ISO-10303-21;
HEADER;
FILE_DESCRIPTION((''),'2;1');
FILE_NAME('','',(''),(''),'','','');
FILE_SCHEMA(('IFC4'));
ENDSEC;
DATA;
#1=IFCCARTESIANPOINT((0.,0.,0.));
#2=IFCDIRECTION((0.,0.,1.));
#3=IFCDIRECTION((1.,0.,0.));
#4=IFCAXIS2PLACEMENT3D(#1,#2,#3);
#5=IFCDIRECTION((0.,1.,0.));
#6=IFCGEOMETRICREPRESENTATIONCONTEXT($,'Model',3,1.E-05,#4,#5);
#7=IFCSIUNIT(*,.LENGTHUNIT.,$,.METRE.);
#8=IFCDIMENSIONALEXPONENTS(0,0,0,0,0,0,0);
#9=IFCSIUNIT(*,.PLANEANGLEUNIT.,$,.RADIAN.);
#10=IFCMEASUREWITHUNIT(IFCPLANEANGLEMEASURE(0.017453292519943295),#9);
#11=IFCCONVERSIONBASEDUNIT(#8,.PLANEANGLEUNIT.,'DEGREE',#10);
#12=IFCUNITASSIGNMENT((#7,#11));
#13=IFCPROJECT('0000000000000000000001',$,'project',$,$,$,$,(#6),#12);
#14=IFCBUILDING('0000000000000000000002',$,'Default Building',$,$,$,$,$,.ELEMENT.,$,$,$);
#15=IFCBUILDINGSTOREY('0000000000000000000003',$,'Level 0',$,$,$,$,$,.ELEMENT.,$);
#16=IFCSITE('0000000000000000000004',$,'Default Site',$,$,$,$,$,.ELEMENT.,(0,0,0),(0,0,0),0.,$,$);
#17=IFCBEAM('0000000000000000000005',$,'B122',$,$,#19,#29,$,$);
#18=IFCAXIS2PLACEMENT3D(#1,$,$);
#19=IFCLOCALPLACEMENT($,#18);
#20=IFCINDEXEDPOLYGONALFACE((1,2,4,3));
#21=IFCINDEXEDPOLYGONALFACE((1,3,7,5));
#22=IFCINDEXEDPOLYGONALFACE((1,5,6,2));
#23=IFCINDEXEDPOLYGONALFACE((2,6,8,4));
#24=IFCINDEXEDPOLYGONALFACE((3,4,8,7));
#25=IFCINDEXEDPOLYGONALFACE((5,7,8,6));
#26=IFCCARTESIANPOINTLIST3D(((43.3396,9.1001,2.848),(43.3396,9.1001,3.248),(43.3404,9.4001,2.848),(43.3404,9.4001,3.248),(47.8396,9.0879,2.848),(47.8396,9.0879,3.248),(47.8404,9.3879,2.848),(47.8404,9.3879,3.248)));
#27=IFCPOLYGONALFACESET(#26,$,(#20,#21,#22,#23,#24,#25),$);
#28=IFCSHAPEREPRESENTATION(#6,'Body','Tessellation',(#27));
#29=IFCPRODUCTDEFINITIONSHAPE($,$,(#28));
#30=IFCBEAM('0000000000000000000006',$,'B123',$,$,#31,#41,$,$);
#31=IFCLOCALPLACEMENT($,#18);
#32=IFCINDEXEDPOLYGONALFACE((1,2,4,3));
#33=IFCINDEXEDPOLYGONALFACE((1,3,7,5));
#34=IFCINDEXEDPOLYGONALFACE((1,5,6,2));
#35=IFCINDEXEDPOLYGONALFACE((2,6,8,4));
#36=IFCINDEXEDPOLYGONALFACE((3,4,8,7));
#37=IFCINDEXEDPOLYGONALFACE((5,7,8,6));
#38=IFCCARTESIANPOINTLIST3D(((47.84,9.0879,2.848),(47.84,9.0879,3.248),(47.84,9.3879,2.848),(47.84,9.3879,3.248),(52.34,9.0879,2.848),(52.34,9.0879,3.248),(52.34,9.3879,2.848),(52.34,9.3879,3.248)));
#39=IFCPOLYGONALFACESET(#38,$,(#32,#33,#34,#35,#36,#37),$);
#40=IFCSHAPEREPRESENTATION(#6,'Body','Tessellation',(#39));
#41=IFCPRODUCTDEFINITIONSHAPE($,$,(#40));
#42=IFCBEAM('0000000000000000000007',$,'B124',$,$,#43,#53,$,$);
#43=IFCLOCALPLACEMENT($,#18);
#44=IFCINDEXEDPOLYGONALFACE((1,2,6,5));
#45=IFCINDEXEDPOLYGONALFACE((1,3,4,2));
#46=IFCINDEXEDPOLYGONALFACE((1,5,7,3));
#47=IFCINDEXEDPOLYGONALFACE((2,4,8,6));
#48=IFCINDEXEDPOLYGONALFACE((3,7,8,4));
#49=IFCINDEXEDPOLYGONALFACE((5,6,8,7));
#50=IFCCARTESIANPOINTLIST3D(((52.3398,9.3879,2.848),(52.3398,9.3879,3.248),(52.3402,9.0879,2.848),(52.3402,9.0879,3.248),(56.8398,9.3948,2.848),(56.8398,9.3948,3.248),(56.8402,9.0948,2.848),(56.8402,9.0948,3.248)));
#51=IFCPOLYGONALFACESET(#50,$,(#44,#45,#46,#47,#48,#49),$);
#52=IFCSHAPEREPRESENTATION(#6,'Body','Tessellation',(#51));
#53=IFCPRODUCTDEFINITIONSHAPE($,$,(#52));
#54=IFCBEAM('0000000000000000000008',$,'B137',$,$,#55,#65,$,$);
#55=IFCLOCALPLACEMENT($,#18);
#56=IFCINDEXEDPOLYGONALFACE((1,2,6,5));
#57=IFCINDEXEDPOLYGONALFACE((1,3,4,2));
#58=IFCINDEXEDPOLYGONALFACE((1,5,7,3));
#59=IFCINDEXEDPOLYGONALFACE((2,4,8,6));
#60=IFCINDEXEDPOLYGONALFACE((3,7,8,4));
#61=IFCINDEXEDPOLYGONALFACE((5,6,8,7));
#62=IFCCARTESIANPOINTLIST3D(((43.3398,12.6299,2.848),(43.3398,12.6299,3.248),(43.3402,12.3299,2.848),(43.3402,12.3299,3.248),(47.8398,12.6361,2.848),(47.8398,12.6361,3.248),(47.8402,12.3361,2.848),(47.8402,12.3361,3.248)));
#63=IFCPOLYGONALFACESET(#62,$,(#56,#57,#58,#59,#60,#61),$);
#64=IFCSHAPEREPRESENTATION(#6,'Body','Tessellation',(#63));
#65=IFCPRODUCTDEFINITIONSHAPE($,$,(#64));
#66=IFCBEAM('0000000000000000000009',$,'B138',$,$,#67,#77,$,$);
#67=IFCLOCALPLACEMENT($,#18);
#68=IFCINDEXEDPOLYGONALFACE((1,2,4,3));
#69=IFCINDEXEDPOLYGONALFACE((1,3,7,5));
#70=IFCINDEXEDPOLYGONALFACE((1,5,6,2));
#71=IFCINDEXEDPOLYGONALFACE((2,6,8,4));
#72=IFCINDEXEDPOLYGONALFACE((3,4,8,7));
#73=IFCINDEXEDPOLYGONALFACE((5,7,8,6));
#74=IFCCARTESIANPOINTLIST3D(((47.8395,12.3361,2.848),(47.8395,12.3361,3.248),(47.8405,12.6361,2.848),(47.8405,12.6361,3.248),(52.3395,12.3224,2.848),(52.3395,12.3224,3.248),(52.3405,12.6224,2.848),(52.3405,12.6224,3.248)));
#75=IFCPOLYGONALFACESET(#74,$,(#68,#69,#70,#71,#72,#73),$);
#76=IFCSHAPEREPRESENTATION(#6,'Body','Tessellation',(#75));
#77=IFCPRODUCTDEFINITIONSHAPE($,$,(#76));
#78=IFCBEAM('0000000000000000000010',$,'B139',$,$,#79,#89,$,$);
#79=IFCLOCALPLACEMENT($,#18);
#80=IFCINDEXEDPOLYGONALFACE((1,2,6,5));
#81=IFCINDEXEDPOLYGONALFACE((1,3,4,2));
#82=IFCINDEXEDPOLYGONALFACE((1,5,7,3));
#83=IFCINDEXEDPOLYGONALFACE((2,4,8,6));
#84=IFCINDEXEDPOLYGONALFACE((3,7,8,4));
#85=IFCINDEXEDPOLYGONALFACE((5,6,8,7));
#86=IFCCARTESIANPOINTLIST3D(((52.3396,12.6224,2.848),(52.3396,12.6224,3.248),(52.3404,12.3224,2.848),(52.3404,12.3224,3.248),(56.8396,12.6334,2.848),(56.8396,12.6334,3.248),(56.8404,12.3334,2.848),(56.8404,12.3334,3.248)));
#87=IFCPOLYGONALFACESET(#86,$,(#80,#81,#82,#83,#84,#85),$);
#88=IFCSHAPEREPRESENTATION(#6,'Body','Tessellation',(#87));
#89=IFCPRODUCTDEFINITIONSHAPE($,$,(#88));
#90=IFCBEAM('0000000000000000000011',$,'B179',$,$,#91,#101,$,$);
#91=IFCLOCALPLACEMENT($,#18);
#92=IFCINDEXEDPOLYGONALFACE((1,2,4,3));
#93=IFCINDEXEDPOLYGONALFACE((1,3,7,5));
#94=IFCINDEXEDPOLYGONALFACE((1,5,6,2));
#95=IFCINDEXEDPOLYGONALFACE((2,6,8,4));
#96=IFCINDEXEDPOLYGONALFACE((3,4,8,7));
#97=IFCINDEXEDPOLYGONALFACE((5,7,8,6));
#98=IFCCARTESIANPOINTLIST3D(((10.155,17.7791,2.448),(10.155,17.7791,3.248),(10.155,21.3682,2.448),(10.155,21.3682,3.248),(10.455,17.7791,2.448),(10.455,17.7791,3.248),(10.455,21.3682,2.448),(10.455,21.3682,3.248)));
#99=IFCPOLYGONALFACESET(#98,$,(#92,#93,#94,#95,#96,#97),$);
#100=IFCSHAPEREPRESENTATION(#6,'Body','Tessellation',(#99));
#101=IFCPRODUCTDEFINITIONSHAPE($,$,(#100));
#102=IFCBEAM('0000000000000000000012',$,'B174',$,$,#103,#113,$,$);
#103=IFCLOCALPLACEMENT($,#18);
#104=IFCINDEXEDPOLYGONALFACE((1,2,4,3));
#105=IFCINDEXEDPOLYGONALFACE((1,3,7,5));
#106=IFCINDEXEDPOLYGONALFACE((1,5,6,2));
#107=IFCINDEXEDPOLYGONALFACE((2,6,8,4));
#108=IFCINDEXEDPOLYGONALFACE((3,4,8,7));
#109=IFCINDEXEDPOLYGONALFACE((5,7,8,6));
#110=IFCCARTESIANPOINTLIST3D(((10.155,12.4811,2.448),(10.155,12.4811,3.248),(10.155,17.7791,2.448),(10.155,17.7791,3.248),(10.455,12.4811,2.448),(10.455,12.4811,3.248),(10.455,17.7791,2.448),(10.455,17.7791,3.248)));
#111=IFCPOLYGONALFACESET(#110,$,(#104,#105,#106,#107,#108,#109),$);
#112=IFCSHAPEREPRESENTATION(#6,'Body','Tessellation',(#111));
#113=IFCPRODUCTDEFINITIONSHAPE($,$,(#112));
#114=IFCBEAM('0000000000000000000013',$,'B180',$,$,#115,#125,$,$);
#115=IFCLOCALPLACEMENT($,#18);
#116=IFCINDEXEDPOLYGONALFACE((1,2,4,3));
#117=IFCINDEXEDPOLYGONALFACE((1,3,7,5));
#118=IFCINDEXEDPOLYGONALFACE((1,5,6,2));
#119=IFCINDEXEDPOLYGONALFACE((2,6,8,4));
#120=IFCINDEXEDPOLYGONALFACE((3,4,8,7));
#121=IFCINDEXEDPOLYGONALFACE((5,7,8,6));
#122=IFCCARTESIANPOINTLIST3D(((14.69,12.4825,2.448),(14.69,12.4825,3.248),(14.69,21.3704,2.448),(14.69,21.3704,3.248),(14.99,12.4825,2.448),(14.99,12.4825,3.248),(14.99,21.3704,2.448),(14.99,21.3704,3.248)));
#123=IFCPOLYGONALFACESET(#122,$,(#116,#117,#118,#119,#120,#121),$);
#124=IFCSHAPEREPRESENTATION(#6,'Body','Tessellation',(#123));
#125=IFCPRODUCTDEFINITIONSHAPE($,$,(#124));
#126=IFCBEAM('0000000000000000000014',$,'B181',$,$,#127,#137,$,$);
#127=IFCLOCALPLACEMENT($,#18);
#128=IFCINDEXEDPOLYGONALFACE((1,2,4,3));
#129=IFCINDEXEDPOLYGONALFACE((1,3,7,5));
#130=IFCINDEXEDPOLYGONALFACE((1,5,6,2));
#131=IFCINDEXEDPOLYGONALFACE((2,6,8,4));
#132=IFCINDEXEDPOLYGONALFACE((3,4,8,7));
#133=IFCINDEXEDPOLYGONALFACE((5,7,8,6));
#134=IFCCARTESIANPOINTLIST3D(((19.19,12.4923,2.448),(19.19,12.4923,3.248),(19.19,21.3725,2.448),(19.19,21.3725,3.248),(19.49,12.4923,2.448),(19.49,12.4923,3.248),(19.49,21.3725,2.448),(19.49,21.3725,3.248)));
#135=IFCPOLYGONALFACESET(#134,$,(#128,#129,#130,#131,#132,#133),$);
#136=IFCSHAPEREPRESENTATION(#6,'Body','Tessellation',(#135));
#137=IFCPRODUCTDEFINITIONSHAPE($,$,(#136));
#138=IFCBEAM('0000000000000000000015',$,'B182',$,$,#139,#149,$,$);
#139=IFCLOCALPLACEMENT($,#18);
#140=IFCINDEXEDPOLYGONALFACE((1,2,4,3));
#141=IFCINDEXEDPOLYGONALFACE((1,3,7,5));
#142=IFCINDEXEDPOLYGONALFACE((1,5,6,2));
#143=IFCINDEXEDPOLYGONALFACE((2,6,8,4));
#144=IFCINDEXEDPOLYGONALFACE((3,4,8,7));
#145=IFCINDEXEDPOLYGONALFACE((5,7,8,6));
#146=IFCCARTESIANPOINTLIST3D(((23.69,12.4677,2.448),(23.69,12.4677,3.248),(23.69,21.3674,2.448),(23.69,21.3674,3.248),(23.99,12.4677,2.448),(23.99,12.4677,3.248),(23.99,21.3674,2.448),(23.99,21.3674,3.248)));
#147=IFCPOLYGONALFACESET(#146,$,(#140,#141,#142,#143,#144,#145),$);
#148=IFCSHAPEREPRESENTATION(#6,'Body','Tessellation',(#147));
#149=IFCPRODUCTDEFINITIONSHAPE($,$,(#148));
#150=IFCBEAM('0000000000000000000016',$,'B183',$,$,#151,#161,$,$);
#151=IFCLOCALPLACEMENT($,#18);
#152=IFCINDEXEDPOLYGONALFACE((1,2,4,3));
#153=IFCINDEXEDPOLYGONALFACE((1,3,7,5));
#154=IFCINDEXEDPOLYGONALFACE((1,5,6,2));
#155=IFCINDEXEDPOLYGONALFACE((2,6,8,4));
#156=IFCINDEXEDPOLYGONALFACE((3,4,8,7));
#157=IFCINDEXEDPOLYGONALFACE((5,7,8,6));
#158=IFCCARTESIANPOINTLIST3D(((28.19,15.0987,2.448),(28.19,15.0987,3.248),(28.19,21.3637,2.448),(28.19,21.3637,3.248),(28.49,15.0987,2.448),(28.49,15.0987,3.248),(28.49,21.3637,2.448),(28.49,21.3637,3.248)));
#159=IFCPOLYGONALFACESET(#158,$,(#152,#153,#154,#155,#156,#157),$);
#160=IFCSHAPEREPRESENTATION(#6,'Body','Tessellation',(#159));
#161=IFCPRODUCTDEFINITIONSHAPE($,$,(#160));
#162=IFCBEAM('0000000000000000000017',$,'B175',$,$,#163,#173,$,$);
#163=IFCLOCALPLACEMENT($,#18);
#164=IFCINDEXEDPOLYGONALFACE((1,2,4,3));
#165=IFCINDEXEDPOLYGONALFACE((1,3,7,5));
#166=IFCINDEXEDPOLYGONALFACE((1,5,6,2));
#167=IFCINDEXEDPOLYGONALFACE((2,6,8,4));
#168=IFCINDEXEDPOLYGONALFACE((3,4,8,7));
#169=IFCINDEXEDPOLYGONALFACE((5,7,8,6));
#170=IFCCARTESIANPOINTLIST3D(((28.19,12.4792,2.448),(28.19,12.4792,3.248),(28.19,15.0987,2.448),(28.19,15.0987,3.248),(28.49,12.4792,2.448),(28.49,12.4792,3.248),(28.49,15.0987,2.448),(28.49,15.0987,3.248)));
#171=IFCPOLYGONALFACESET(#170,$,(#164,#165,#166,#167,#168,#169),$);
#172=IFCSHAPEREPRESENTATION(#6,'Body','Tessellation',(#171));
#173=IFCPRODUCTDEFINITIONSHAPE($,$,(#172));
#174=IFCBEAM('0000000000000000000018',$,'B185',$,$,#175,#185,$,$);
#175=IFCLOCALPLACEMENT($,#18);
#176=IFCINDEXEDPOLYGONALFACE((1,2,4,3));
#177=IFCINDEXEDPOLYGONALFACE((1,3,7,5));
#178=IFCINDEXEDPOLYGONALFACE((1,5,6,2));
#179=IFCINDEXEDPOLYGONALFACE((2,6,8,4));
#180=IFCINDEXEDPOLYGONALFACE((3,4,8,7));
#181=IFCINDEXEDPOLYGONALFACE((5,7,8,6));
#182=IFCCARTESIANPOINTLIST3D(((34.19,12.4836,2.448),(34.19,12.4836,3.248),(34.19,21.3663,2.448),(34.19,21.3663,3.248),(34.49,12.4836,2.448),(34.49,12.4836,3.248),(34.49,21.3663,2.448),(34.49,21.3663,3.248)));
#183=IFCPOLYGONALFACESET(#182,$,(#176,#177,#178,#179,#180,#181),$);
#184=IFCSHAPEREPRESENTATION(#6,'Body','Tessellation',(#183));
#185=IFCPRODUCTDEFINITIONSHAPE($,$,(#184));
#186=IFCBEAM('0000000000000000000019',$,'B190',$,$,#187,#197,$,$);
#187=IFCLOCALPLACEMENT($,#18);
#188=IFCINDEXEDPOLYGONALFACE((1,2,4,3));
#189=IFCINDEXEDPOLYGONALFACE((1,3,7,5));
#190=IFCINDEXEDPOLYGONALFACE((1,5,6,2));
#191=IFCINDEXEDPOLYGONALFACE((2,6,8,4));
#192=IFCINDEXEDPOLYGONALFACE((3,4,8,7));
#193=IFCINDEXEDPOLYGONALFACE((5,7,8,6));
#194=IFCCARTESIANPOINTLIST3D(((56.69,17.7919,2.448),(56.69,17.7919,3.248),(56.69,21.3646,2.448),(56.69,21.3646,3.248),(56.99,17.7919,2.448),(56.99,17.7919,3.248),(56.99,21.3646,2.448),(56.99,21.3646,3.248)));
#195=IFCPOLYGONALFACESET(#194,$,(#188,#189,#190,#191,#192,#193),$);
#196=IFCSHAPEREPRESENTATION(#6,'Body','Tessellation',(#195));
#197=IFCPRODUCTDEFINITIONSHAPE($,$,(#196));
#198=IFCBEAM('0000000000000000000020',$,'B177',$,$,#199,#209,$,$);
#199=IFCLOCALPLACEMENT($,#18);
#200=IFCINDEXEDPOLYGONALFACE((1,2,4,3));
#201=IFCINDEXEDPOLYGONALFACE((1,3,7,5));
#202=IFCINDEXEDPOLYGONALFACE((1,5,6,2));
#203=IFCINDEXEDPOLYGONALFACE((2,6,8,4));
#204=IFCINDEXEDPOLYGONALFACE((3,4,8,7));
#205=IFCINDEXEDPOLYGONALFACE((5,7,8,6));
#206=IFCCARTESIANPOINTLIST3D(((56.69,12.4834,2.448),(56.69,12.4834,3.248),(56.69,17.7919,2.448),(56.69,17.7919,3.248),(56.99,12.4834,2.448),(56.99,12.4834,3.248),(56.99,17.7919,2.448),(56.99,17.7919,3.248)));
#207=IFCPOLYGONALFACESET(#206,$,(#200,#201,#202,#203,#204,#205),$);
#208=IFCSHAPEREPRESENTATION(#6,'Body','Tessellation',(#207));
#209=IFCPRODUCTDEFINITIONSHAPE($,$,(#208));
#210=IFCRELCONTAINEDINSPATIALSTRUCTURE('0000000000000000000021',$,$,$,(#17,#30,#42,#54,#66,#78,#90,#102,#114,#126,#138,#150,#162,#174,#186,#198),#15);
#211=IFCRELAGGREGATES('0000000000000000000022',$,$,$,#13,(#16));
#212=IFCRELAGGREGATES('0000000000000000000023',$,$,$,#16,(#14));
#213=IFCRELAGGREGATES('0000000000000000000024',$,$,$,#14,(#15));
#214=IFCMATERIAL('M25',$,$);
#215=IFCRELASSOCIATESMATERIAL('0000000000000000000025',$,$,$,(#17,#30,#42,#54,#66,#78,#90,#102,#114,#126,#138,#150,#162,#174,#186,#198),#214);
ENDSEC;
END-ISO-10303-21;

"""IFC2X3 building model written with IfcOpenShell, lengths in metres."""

from ifc_helpers import new_model, entity, si_unit, converted_unit, direction, frame, frame_2d, origin_with_axes, place, context, project, spatial, rectangle, extrude, material, element, save


model = new_model("IFC2X3")

# Units and contexts
model_context = context("Model", 3, precision=1e-05, world=origin_with_axes(), true_north=direction((0.0, 1.0, 0.0)))
ifc_project = project(units=[si_unit("LENGTHUNIT", "METRE"), converted_unit("PLANEANGLEUNIT", "DEGREE", entity("IfcPlaneAngleMeasure", 0.017453292519943295), si_unit("PLANEANGLEUNIT", "RADIAN"), dimensions=[0, 0, 0, 0, 0, 0, 0])], contexts=[model_context])

# Site, building, storey
site = spatial("IfcSite", under=ifc_project, Name="Default Site", CompositionType="ELEMENT", RefLatitude=(0, 0, 0), RefLongitude=(0, 0, 0), RefElevation=0.0)
building = spatial("IfcBuilding", under=site, Name="Default Building", CompositionType="ELEMENT")
storey = spatial("IfcBuildingStorey", under=building, Name="Level 0", CompositionType="ELEMENT")

# Beams
ifc_material = material(Name="M25")
placement = place(None, origin_with_axes())
element("IfcBeam", 1, at=placement, inside=storey, material=ifc_material, Name="B122", context=model_context, shape_type="SweptSolid", body=[
    extrude(rectangle(XDim=0.3, YDim=0.4, at=frame_2d((0.0, 0.0), x_axis=(0.0, 1.0, 0.0))), frame((43.34, 9.2501, 3.048), z_axis=(0.999996, -0.002702, 0.0), x_axis=(0.0, 0.0, -1.0)), (0.0, 0.0, 1.0), 4.5),
])
element("IfcBeam", 2, at=placement, inside=storey, material=ifc_material, Name="B123", context=model_context, shape_type="SweptSolid", body=[
    extrude(rectangle(XDim=0.3, YDim=0.4, at=frame_2d((0.0, 0.0), x_axis=(0.0, 1.0, 0.0))), frame((47.84, 9.2379, 3.048), z_axis=(1.0, 0.0, 0.0), x_axis=(0.0, 0.0, -1.0)), (0.0, 0.0, 1.0), 4.5),
])
element("IfcBeam", 3, at=placement, inside=storey, material=ifc_material, Name="B124", context=model_context, shape_type="SweptSolid", body=[
    extrude(rectangle(XDim=0.3, YDim=0.4, at=frame_2d((0.0, 0.0), x_axis=(0.0, 1.0, 0.0))), frame((52.34, 9.2379, 3.048), z_axis=(0.999999, 0.001537, 0.0), x_axis=(0.0, 0.0, -1.0)), (0.0, 0.0, 1.0), 4.5),
])
element("IfcBeam", 4, at=placement, inside=storey, material=ifc_material, Name="B137", context=model_context, shape_type="SweptSolid", body=[
    extrude(rectangle(XDim=0.3, YDim=0.4, at=frame_2d((0.0, 0.0), x_axis=(0.0, 1.0, 0.0))), frame((43.34, 12.4799, 3.048), z_axis=(0.999999, 0.001374, 0.0), x_axis=(0.0, 0.0, -1.0)), (0.0, 0.0, 1.0), 4.5),
])
element("IfcBeam", 5, at=placement, inside=storey, material=ifc_material, Name="B138", context=model_context, shape_type="SweptSolid", body=[
    extrude(rectangle(XDim=0.3, YDim=0.4, at=frame_2d((0.0, 0.0), x_axis=(0.0, 1.0, 0.0))), frame((47.84, 12.4861, 3.048), z_axis=(0.999995, -0.003045, 0.0), x_axis=(0.0, 0.0, -1.0)), (0.0, 0.0, 1.0), 4.5),
])
element("IfcBeam", 6, at=placement, inside=storey, material=ifc_material, Name="B139", context=model_context, shape_type="SweptSolid", body=[
    extrude(rectangle(XDim=0.3, YDim=0.4, at=frame_2d((0.0, 0.0), x_axis=(0.0, 1.0, 0.0))), frame((52.34, 12.4724, 3.048), z_axis=(0.999997, 0.002456, 0.0), x_axis=(0.0, 0.0, -1.0)), (0.0, 0.0, 1.0), 4.5),
])
element("IfcBeam", 7, at=placement, inside=storey, material=ifc_material, Name="B179", context=model_context, shape_type="SweptSolid", body=[
    extrude(rectangle(XDim=0.3, YDim=0.8, at=frame_2d((0.0, 0.0), x_axis=(0.0, 1.0, 0.0))), frame((10.305, 21.3682, 2.848), z_axis=(0.0, -1.0, 0.0), x_axis=(0.0, 0.0, -1.0)), (0.0, 0.0, 1.0), 3.5891),
])
element("IfcBeam", 8, at=placement, inside=storey, material=ifc_material, Name="B174", context=model_context, shape_type="SweptSolid", body=[
    extrude(rectangle(XDim=0.3, YDim=0.8, at=frame_2d((0.0, 0.0), x_axis=(0.0, 1.0, 0.0))), frame((10.305, 17.7791, 2.848), z_axis=(0.0, -1.0, 0.0), x_axis=(0.0, 0.0, -1.0)), (0.0, 0.0, 1.0), 5.298),
])
element("IfcBeam", 9, at=placement, inside=storey, material=ifc_material, Name="B180", context=model_context, shape_type="SweptSolid", body=[
    extrude(rectangle(XDim=0.3, YDim=0.8, at=frame_2d((0.0, 0.0), x_axis=(0.0, 1.0, 0.0))), frame((14.84, 21.3704, 2.848), z_axis=(0.0, -1.0, 0.0), x_axis=(0.0, 0.0, -1.0)), (0.0, 0.0, 1.0), 8.8879),
])
element("IfcBeam", 10, at=placement, inside=storey, material=ifc_material, Name="B181", context=model_context, shape_type="SweptSolid", body=[
    extrude(rectangle(XDim=0.3, YDim=0.8, at=frame_2d((0.0, 0.0), x_axis=(0.0, 1.0, 0.0))), frame((19.34, 21.3725, 2.848), z_axis=(0.0, -1.0, 0.0), x_axis=(0.0, 0.0, -1.0)), (0.0, 0.0, 1.0), 8.8802),
])
element("IfcBeam", 11, at=placement, inside=storey, material=ifc_material, Name="B182", context=model_context, shape_type="SweptSolid", body=[
    extrude(rectangle(XDim=0.3, YDim=0.8, at=frame_2d((0.0, 0.0), x_axis=(0.0, 1.0, 0.0))), frame((23.84, 21.3674, 2.848), z_axis=(0.0, -1.0, 0.0), x_axis=(0.0, 0.0, -1.0)), (0.0, 0.0, 1.0), 8.8997),
])
element("IfcBeam", 12, at=placement, inside=storey, material=ifc_material, Name="B183", context=model_context, shape_type="SweptSolid", body=[
    extrude(rectangle(XDim=0.3, YDim=0.8, at=frame_2d((0.0, 0.0), x_axis=(0.0, 1.0, 0.0))), frame((28.34, 21.3637, 2.848), z_axis=(0.0, -1.0, 0.0), x_axis=(0.0, 0.0, -1.0)), (0.0, 0.0, 1.0), 6.265),
])
element("IfcBeam", 13, at=placement, inside=storey, material=ifc_material, Name="B175", context=model_context, shape_type="SweptSolid", body=[
    extrude(rectangle(XDim=0.3, YDim=0.8, at=frame_2d((0.0, 0.0), x_axis=(0.0, 1.0, 0.0))), frame((28.34, 15.0987, 2.848), z_axis=(0.0, -1.0, 0.0), x_axis=(0.0, 0.0, -1.0)), (0.0, 0.0, 1.0), 2.6195),
])
element("IfcBeam", 14, at=placement, inside=storey, material=ifc_material, Name="B185", context=model_context, shape_type="SweptSolid", body=[
    extrude(rectangle(XDim=0.3, YDim=0.8, at=frame_2d((0.0, 0.0), x_axis=(0.0, 1.0, 0.0))), frame((34.34, 12.4836, 2.848), z_axis=(0.0, 1.0, 0.0), x_axis=(0.0, 0.0, -1.0)), (0.0, 0.0, 1.0), 8.8827),
])
element("IfcBeam", 15, at=placement, inside=storey, material=ifc_material, Name="B190", context=model_context, shape_type="SweptSolid", body=[
    extrude(rectangle(XDim=0.3, YDim=0.8, at=frame_2d((0.0, 0.0), x_axis=(0.0, 1.0, 0.0))), frame((56.84, 17.7919, 2.848), z_axis=(0.0, 1.0, 0.0), x_axis=(0.0, 0.0, -1.0)), (0.0, 0.0, 1.0), 3.5727),
])
element("IfcBeam", 16, at=placement, inside=storey, material=ifc_material, Name="B177", context=model_context, shape_type="SweptSolid", body=[
    extrude(rectangle(XDim=0.3, YDim=0.8, at=frame_2d((0.0, 0.0), x_axis=(0.0, 1.0, 0.0))), frame((56.84, 12.4834, 2.848), z_axis=(0.0, 1.0, 0.0), x_axis=(0.0, 0.0, -1.0)), (0.0, 0.0, 1.0), 5.3085),
])

save(model, "model.ifc")
